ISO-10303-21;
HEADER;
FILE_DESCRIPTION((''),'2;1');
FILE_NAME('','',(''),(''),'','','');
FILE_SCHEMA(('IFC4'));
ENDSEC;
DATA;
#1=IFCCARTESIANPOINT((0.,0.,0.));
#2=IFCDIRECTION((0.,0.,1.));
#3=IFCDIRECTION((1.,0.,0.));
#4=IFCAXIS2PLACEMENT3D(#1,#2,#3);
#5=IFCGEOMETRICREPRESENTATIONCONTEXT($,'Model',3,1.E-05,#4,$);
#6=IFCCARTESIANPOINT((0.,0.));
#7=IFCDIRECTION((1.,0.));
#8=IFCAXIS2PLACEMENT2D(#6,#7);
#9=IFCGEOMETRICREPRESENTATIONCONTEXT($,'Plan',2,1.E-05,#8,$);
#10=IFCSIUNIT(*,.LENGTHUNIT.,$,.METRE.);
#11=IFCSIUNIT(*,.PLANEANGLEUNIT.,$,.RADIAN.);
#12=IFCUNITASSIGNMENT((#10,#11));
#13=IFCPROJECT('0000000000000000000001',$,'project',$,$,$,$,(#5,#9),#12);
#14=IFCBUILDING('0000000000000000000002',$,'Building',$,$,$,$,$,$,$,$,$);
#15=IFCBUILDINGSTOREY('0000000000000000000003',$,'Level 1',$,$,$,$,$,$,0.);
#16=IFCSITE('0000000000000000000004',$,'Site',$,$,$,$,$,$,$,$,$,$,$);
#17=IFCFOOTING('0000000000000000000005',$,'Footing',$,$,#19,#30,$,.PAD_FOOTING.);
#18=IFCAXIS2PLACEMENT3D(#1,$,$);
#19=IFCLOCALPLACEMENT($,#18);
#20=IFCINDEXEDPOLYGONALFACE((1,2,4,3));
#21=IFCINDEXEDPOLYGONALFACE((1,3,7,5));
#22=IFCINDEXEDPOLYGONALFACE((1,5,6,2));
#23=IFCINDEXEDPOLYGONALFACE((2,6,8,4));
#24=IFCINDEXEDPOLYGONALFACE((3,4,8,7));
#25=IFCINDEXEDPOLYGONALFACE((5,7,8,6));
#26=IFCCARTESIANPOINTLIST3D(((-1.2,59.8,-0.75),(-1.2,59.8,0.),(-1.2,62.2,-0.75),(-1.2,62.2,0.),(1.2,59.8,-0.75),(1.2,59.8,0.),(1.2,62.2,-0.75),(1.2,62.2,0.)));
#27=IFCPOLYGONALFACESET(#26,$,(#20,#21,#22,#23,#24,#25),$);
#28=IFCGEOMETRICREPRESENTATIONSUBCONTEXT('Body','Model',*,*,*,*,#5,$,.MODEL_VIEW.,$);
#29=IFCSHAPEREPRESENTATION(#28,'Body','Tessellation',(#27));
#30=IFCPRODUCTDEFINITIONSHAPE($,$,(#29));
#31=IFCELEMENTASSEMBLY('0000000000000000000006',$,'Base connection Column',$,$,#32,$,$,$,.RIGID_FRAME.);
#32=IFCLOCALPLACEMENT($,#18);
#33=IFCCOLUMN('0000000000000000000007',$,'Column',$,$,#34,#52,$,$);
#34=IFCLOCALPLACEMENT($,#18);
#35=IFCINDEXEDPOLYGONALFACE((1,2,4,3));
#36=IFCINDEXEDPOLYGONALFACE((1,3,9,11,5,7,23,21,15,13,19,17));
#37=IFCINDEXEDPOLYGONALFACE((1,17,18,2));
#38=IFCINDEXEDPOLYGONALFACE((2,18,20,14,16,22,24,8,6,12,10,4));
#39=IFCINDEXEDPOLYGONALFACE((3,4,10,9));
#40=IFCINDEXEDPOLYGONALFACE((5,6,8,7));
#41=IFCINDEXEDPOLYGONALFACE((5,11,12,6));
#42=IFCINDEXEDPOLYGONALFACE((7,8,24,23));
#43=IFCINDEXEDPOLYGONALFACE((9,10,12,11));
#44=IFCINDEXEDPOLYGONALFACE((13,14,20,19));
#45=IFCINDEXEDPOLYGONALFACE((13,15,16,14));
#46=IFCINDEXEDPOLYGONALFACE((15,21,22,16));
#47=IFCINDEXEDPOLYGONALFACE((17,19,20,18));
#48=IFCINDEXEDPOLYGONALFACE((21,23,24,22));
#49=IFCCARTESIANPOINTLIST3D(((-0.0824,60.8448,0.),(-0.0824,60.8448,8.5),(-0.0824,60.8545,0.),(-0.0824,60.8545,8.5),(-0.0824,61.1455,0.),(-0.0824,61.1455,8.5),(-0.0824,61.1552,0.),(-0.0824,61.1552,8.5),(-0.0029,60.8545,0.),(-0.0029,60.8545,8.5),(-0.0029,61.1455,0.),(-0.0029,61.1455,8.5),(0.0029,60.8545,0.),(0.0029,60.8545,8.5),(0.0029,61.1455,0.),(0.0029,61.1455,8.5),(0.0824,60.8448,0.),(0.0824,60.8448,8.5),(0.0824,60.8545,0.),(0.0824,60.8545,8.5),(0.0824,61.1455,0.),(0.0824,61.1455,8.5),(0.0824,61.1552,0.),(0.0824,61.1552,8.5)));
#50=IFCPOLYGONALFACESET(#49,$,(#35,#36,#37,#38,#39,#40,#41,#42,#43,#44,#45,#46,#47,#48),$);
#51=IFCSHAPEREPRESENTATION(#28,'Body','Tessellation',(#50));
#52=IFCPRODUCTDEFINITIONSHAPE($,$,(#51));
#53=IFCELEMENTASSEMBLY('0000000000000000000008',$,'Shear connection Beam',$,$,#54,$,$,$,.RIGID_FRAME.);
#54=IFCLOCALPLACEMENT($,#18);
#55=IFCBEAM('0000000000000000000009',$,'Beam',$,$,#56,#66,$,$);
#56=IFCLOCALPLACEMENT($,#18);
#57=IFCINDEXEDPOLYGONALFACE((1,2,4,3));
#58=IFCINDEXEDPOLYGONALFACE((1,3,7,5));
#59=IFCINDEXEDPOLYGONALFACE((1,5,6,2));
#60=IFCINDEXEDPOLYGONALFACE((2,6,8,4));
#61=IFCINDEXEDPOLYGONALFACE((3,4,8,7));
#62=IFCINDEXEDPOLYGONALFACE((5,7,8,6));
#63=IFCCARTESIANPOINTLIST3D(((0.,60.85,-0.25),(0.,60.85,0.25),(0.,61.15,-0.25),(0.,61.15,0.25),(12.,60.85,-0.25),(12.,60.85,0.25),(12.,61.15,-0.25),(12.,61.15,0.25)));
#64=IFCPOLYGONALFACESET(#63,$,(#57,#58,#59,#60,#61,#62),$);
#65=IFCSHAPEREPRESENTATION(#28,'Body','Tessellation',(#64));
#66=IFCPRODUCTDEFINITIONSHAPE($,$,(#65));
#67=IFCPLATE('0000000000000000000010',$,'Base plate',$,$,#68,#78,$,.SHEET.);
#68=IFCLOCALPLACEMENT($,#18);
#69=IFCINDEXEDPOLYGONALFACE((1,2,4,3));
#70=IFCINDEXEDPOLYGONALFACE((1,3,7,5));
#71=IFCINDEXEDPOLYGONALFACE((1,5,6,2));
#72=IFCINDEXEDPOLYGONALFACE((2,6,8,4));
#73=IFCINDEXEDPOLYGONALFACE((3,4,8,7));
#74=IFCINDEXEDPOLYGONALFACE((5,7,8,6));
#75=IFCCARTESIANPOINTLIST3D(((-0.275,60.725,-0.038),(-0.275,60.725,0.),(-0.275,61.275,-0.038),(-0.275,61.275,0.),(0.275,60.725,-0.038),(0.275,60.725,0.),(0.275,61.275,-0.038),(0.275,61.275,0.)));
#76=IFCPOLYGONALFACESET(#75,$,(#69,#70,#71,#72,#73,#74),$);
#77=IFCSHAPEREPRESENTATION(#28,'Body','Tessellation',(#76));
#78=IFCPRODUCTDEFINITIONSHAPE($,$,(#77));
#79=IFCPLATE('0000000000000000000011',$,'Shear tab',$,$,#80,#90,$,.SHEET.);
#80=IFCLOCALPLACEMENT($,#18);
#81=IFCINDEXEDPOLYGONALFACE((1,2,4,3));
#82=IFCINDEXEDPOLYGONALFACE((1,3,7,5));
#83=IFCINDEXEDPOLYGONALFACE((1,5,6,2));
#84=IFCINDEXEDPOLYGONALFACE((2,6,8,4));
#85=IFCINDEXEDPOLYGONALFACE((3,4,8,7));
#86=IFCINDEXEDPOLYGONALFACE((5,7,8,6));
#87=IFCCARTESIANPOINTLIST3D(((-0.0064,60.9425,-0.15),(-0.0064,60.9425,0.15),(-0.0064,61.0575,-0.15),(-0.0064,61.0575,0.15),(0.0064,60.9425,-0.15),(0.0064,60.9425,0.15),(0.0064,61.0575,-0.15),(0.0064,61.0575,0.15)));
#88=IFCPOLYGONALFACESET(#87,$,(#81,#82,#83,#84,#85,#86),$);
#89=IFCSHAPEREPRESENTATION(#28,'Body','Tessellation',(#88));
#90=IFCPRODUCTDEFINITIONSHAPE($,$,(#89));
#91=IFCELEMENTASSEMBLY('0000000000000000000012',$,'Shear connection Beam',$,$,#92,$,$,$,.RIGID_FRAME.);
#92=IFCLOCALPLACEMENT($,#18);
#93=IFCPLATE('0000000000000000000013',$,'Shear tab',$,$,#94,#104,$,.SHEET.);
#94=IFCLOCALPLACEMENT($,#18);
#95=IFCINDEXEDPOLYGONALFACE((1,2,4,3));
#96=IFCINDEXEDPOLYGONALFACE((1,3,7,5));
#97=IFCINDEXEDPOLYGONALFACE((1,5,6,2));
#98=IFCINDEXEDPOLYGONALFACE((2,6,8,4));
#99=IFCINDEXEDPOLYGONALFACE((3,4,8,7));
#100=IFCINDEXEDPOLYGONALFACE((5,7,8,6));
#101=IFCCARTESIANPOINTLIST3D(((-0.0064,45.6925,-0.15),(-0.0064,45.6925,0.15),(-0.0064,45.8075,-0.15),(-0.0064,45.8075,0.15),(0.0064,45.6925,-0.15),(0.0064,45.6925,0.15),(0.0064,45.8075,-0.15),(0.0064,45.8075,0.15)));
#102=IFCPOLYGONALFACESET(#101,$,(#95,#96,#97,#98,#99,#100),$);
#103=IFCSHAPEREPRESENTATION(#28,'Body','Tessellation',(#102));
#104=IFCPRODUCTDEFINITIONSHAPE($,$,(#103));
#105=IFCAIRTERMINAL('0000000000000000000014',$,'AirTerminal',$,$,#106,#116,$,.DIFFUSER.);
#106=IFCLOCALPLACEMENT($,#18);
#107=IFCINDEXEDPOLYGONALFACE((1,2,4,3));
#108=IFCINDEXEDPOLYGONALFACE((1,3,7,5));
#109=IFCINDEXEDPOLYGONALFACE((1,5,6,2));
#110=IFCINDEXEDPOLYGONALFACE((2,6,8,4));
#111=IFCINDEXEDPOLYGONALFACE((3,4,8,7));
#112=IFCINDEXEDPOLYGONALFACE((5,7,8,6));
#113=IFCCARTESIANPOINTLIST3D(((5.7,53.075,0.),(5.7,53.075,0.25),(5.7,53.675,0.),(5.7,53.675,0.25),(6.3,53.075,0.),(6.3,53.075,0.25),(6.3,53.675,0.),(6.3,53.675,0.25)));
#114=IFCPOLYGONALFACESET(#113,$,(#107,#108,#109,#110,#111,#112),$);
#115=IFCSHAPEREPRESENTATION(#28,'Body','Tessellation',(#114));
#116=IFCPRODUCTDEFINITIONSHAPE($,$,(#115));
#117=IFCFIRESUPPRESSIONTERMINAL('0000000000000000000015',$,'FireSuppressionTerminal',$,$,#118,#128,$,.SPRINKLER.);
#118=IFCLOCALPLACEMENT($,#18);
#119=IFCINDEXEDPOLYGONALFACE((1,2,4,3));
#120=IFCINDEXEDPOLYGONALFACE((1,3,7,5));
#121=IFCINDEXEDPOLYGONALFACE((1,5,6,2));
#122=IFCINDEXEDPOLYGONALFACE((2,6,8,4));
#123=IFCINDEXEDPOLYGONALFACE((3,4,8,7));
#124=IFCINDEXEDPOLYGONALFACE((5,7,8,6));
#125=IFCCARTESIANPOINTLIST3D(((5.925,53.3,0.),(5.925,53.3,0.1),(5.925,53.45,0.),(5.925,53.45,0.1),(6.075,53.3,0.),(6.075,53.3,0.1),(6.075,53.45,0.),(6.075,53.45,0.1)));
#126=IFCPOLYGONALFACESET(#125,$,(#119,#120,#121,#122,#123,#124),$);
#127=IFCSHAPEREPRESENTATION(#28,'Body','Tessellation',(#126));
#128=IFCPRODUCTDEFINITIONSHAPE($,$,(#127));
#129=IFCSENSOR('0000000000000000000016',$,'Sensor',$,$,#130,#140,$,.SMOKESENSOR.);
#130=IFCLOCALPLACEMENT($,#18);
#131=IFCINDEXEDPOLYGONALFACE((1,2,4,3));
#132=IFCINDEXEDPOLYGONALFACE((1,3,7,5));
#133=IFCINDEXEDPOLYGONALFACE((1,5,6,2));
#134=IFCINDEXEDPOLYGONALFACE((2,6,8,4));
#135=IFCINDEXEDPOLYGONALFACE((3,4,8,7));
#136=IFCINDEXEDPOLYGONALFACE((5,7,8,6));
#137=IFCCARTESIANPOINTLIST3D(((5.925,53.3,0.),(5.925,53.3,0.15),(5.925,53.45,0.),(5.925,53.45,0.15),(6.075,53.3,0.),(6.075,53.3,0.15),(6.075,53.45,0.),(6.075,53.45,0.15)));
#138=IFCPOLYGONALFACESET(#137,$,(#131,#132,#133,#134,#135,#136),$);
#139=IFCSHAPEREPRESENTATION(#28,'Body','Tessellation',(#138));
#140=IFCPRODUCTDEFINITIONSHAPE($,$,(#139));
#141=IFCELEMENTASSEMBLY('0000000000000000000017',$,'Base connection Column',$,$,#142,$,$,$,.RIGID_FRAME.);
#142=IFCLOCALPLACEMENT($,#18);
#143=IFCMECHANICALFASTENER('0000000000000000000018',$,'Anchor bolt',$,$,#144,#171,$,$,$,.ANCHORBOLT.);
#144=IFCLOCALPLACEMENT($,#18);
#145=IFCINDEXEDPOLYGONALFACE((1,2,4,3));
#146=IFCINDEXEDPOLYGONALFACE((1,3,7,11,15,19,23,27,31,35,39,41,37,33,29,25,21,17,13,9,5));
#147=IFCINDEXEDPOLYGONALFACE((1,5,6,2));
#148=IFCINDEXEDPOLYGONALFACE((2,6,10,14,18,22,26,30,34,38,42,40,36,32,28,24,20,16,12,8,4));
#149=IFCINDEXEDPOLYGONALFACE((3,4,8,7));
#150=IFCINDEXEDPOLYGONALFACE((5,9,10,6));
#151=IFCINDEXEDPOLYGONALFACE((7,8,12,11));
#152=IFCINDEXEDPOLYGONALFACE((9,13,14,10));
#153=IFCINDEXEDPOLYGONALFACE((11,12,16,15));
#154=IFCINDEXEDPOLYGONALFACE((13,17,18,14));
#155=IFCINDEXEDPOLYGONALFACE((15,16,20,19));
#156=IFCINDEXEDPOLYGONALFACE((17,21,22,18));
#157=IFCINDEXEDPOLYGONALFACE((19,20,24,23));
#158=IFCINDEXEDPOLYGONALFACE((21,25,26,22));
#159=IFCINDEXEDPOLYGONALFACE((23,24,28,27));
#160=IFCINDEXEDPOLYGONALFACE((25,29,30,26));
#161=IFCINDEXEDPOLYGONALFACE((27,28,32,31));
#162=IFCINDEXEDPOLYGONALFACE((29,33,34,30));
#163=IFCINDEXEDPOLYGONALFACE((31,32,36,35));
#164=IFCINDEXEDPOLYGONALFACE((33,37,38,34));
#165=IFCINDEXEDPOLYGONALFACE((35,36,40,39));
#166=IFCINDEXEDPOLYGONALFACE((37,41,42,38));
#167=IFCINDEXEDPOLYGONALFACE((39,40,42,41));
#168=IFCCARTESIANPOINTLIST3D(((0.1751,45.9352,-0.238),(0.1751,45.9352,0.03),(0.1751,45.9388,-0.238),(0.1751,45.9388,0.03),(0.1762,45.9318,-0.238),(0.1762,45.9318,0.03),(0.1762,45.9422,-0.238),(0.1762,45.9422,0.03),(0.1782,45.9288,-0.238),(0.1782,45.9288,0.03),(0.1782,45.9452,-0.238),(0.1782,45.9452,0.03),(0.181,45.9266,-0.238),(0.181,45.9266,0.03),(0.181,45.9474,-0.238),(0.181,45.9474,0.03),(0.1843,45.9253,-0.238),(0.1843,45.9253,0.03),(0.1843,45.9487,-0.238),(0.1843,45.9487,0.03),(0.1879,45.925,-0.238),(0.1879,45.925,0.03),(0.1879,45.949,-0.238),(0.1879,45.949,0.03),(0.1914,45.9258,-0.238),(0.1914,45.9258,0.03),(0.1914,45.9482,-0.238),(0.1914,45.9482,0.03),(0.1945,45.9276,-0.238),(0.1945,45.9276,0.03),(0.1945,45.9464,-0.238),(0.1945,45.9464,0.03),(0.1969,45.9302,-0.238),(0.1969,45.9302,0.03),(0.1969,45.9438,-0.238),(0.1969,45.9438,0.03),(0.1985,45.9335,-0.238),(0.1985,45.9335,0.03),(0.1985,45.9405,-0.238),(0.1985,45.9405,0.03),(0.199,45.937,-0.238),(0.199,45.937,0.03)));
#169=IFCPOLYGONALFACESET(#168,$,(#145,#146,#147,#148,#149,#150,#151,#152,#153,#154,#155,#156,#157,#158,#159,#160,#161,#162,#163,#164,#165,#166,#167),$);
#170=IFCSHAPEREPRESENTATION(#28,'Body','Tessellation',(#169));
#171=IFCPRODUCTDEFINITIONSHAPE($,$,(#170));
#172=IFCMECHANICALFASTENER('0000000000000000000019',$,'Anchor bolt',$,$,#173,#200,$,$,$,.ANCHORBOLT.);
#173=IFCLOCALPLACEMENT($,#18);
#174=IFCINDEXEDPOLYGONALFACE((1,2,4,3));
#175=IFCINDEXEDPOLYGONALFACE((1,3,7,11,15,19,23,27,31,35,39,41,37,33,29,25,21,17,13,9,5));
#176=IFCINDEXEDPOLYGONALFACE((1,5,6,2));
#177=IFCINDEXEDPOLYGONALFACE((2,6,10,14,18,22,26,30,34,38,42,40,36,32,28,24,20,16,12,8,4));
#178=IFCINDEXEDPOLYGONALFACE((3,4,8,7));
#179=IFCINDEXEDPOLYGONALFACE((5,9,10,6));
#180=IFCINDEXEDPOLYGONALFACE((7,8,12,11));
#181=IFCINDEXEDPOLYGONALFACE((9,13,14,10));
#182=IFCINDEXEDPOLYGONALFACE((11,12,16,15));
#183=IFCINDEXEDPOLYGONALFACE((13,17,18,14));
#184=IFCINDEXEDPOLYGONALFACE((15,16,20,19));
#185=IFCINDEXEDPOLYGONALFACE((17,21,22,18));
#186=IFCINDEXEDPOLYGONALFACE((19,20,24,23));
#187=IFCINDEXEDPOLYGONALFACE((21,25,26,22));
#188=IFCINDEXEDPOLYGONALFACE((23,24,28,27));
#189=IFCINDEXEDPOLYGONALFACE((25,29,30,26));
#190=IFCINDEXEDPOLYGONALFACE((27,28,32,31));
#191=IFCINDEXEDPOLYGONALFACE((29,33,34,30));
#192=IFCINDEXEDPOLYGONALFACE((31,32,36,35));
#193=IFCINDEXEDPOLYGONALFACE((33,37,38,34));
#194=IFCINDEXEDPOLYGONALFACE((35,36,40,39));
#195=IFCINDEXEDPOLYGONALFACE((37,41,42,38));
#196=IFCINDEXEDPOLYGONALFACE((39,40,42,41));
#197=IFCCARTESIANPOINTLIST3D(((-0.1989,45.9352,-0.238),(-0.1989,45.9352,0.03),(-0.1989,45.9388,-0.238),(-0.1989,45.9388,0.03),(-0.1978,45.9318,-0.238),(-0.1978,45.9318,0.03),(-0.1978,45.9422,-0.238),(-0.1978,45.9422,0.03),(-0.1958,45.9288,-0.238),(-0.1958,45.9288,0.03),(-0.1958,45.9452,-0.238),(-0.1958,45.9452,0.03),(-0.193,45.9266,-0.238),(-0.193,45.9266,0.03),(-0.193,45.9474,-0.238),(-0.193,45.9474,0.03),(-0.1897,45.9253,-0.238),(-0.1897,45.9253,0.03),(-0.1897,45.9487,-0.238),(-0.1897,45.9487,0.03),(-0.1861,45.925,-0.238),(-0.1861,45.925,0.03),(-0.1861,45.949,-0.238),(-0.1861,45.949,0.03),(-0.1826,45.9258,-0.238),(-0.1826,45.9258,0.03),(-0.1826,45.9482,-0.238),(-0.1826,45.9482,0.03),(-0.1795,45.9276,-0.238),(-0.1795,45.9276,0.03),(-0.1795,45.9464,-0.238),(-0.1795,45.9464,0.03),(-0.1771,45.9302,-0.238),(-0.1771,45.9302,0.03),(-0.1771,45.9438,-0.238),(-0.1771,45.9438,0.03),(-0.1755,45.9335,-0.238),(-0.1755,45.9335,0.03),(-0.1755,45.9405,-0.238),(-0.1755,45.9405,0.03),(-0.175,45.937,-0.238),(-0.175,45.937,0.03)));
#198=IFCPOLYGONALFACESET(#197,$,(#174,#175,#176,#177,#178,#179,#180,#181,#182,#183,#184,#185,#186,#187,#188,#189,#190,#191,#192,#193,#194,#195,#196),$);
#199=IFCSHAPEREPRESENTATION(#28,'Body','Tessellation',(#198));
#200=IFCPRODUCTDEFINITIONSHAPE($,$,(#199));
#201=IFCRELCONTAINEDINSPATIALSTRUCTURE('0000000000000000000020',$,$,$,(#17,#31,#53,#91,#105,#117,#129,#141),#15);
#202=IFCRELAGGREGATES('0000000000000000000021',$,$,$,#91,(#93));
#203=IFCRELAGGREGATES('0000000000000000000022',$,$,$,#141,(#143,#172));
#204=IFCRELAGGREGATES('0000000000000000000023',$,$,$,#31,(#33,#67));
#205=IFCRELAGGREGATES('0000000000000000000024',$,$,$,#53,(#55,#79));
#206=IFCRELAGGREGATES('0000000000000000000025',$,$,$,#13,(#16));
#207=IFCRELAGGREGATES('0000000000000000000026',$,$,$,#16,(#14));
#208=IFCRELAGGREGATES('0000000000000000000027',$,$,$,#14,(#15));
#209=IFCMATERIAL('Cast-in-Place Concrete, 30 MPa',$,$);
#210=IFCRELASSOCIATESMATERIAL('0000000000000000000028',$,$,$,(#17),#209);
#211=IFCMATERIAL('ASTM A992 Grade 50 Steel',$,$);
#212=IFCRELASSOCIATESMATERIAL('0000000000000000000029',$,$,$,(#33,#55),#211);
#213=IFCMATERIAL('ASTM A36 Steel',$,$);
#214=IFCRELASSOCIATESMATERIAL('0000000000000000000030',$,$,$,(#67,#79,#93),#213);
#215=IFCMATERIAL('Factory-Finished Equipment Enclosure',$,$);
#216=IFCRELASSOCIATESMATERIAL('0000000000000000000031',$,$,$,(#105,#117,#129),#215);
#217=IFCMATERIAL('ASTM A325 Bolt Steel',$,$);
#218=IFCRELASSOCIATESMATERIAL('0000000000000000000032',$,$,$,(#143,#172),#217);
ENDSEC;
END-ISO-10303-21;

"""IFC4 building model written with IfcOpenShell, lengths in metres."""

from ifc_helpers import new_model, si_unit, frame, origin_with_axes, origin_2d, origin_2d_with_axis, place, context, subcontext, project, spatial, rectangle, circle, i_section, extrude, material, element, aggregate, save


model = new_model("IFC4")

# Units and contexts
model_context = context("Model", 3, precision=1e-05, world=origin_with_axes())
plan_context = context("Plan", 2, precision=1e-05, world=origin_2d_with_axis())
body_context = subcontext(model_context, "Body", "Model", "MODEL_VIEW")
ifc_project = project(units=[si_unit("LENGTHUNIT", "METRE"), si_unit("PLANEANGLEUNIT", "RADIAN")], contexts=[model_context, plan_context])

# Site, building, storey
site = spatial("IfcSite", under=ifc_project, Name="Site")
building = spatial("IfcBuilding", under=site, Name="Building")
storey = spatial("IfcBuildingStorey", under=building, Name="Level 1", Elevation=0.0)

# Footing
ifc_material_1 = material(Name="Cast-in-Place Concrete, 30 MPa")
footing_placement = place(None, frame((0.0, 61.0, -0.75), z_axis=(0.0, 0.0, 1.0), x_axis=(1.0, 0.0, 0.0)))
element("IfcFooting", 1, at=footing_placement, inside=storey, material=ifc_material_1, Name="Footing", PredefinedType="PAD_FOOTING", context=body_context, shape_type="SweptSolid", body=[
    extrude(rectangle(XDim=2.4, YDim=2.4, at=origin_2d_with_axis()), origin_with_axes(), (0.0, 0.0, 1.0), 0.75),
])

# Element assembly, column
assembly_1 = element("IfcElementAssembly", 2, inside=storey, Name="Base connection Column", PredefinedType="RIGID_FRAME")
ifc_material_2 = material(Name="ASTM A992 Grade 50 Steel")
column_placement = place(None, frame((0.0, 61.0, 0.0), z_axis=(0.0, 0.0, 1.0), x_axis=(1.0, 0.0, 0.0)))
column = element("IfcColumn", 3, at=column_placement, material=ifc_material_2, Name="Column", context=body_context, shape_type="SweptSolid", body=[
    extrude(i_section(OverallWidth=0.1648, OverallDepth=0.3104, WebThickness=0.0058, FlangeThickness=0.0097, at=origin_2d_with_axis()), origin_with_axes(), (0.0, 0.0, 1.0), 8.5),
])

# Element assembly, beam
assembly_2 = element("IfcElementAssembly", 4, inside=storey, Name="Shear connection Beam", PredefinedType="RIGID_FRAME")
beam_placement = place(None, frame((0.0, 61.0, 0.0), z_axis=(1.0, 0.0, 0.0), x_axis=(0.0, 1.0, 0.0)))
beam = element("IfcBeam", 5, at=beam_placement, material=ifc_material_2, Name="Beam", context=body_context, shape_type="SweptSolid", body=[
    extrude(rectangle(XDim=0.3, YDim=0.5, at=origin_2d_with_axis()), origin_with_axes(), (0.0, 0.0, 1.0), 12.0),
])

# Plates
ifc_material_3 = material(Name="ASTM A36 Steel")
plate_1_placement = place(None, frame((0.0, 61.0, -0.038), z_axis=(0.0, 0.0, 1.0), x_axis=(1.0, 0.0, 0.0)))
plate_1 = element("IfcPlate", 6, at=plate_1_placement, material=ifc_material_3, Name="Base plate", PredefinedType="SHEET", context=body_context, shape_type="SweptSolid", body=[
    extrude(rectangle(XDim=0.55, YDim=0.55, at=origin_2d_with_axis()), origin_with_axes(), (0.0, 0.0, 1.0), 0.038),
])
plate_2_placement = place(None, frame((0.0, 61.0, -0.15), z_axis=(0.0, 0.0, 1.0), x_axis=(1.0, 0.0, 0.0)))
plate_2 = element("IfcPlate", 7, at=plate_2_placement, material=ifc_material_3, Name="Shear tab", PredefinedType="SHEET", context=body_context, shape_type="SweptSolid", body=[
    extrude(rectangle(XDim=0.0127, YDim=0.115, at=origin_2d_with_axis()), origin_with_axes(), (0.0, 0.0, 1.0), 0.3),
])

# Element assembly, plate
assembly_3 = element("IfcElementAssembly", 8, inside=storey, Name="Shear connection Beam", PredefinedType="RIGID_FRAME")
plate_3_placement = place(None, frame((0.0, 45.75, -0.15), z_axis=(0.0, 0.0, 1.0), x_axis=(1.0, 0.0, 0.0)))
plate_3 = element("IfcPlate", 9, at=plate_3_placement, material=ifc_material_3, Name="Shear tab", PredefinedType="SHEET", context=body_context, shape_type="SweptSolid", body=[
    extrude(rectangle(XDim=0.0127, YDim=0.115, at=origin_2d_with_axis()), origin_with_axes(), (0.0, 0.0, 1.0), 0.3),
])
aggregate(assembly_3, [plate_3])

# Air terminal
ifc_material_4 = material(Name="Factory-Finished Equipment Enclosure")
air_terminal_placement = place(None, frame((6.0, 53.375, 0.0), z_axis=(0.0, 0.0, 1.0), x_axis=(1.0, 0.0, 0.0)))
element("IfcAirTerminal", 10, at=air_terminal_placement, inside=storey, material=ifc_material_4, Name="AirTerminal", PredefinedType="DIFFUSER", context=body_context, shape_type="SweptSolid", body=[
    extrude(rectangle(XDim=0.6, YDim=0.6, at=origin_2d_with_axis()), origin_with_axes(), (0.0, 0.0, 1.0), 0.25),
])

# Fire suppression terminal
fire_suppression_terminal_placement = place(None, frame((6.0, 53.375, 0.0), z_axis=(0.0, 0.0, 1.0), x_axis=(1.0, 0.0, 0.0)))
element("IfcFireSuppressionTerminal", 11, at=fire_suppression_terminal_placement, inside=storey, material=ifc_material_4, Name="FireSuppressionTerminal", PredefinedType="SPRINKLER", context=body_context, shape_type="SweptSolid", body=[
    extrude(rectangle(XDim=0.15, YDim=0.15, at=origin_2d_with_axis()), origin_with_axes(), (0.0, 0.0, 1.0), 0.1),
])

# Sensor
sensor_placement = place(None, frame((6.0, 53.375, 0.0), z_axis=(0.0, 0.0, 1.0), x_axis=(1.0, 0.0, 0.0)))
element("IfcSensor", 12, at=sensor_placement, inside=storey, material=ifc_material_4, Name="Sensor", PredefinedType="SMOKESENSOR", context=body_context, shape_type="SweptSolid", body=[
    extrude(rectangle(XDim=0.15, YDim=0.15, at=origin_2d_with_axis()), origin_with_axes(), (0.0, 0.0, 1.0), 0.15),
])

# Element assembly, mechanical fasteners
assembly_4 = element("IfcElementAssembly", 13, inside=storey, Name="Base connection Column", PredefinedType="RIGID_FRAME")
ifc_material_5 = material(Name="ASTM A325 Bolt Steel")
mechanical_fastener_1_placement = place(None, frame((0.187, 45.937, -0.238), z_axis=(0.0, 0.0, 1.0), x_axis=(1.0, 0.0, 0.0)))
mechanical_fastener_1 = element("IfcMechanicalFastener", 14, at=mechanical_fastener_1_placement, material=ifc_material_5, Name="Anchor bolt", PredefinedType="ANCHORBOLT", context=body_context, shape_type="SweptSolid", body=[
    extrude(circle(Radius=0.012, at=origin_2d()), origin_with_axes(), (0.0, 0.0, 1.0), 0.268),
])
mechanical_fastener_2_placement = place(None, frame((-0.187, 45.937, -0.238), z_axis=(0.0, 0.0, 1.0), x_axis=(1.0, 0.0, 0.0)))
mechanical_fastener_2 = element("IfcMechanicalFastener", 15, at=mechanical_fastener_2_placement, material=ifc_material_5, Name="Anchor bolt", PredefinedType="ANCHORBOLT", context=body_context, shape_type="SweptSolid", body=[
    extrude(circle(Radius=0.012, at=origin_2d()), origin_with_axes(), (0.0, 0.0, 1.0), 0.268),
])
aggregate(assembly_4, [mechanical_fastener_1, mechanical_fastener_2])

aggregate(assembly_1, [column, plate_1])

aggregate(assembly_2, [beam, plate_2])

save(model, "model.ifc")
